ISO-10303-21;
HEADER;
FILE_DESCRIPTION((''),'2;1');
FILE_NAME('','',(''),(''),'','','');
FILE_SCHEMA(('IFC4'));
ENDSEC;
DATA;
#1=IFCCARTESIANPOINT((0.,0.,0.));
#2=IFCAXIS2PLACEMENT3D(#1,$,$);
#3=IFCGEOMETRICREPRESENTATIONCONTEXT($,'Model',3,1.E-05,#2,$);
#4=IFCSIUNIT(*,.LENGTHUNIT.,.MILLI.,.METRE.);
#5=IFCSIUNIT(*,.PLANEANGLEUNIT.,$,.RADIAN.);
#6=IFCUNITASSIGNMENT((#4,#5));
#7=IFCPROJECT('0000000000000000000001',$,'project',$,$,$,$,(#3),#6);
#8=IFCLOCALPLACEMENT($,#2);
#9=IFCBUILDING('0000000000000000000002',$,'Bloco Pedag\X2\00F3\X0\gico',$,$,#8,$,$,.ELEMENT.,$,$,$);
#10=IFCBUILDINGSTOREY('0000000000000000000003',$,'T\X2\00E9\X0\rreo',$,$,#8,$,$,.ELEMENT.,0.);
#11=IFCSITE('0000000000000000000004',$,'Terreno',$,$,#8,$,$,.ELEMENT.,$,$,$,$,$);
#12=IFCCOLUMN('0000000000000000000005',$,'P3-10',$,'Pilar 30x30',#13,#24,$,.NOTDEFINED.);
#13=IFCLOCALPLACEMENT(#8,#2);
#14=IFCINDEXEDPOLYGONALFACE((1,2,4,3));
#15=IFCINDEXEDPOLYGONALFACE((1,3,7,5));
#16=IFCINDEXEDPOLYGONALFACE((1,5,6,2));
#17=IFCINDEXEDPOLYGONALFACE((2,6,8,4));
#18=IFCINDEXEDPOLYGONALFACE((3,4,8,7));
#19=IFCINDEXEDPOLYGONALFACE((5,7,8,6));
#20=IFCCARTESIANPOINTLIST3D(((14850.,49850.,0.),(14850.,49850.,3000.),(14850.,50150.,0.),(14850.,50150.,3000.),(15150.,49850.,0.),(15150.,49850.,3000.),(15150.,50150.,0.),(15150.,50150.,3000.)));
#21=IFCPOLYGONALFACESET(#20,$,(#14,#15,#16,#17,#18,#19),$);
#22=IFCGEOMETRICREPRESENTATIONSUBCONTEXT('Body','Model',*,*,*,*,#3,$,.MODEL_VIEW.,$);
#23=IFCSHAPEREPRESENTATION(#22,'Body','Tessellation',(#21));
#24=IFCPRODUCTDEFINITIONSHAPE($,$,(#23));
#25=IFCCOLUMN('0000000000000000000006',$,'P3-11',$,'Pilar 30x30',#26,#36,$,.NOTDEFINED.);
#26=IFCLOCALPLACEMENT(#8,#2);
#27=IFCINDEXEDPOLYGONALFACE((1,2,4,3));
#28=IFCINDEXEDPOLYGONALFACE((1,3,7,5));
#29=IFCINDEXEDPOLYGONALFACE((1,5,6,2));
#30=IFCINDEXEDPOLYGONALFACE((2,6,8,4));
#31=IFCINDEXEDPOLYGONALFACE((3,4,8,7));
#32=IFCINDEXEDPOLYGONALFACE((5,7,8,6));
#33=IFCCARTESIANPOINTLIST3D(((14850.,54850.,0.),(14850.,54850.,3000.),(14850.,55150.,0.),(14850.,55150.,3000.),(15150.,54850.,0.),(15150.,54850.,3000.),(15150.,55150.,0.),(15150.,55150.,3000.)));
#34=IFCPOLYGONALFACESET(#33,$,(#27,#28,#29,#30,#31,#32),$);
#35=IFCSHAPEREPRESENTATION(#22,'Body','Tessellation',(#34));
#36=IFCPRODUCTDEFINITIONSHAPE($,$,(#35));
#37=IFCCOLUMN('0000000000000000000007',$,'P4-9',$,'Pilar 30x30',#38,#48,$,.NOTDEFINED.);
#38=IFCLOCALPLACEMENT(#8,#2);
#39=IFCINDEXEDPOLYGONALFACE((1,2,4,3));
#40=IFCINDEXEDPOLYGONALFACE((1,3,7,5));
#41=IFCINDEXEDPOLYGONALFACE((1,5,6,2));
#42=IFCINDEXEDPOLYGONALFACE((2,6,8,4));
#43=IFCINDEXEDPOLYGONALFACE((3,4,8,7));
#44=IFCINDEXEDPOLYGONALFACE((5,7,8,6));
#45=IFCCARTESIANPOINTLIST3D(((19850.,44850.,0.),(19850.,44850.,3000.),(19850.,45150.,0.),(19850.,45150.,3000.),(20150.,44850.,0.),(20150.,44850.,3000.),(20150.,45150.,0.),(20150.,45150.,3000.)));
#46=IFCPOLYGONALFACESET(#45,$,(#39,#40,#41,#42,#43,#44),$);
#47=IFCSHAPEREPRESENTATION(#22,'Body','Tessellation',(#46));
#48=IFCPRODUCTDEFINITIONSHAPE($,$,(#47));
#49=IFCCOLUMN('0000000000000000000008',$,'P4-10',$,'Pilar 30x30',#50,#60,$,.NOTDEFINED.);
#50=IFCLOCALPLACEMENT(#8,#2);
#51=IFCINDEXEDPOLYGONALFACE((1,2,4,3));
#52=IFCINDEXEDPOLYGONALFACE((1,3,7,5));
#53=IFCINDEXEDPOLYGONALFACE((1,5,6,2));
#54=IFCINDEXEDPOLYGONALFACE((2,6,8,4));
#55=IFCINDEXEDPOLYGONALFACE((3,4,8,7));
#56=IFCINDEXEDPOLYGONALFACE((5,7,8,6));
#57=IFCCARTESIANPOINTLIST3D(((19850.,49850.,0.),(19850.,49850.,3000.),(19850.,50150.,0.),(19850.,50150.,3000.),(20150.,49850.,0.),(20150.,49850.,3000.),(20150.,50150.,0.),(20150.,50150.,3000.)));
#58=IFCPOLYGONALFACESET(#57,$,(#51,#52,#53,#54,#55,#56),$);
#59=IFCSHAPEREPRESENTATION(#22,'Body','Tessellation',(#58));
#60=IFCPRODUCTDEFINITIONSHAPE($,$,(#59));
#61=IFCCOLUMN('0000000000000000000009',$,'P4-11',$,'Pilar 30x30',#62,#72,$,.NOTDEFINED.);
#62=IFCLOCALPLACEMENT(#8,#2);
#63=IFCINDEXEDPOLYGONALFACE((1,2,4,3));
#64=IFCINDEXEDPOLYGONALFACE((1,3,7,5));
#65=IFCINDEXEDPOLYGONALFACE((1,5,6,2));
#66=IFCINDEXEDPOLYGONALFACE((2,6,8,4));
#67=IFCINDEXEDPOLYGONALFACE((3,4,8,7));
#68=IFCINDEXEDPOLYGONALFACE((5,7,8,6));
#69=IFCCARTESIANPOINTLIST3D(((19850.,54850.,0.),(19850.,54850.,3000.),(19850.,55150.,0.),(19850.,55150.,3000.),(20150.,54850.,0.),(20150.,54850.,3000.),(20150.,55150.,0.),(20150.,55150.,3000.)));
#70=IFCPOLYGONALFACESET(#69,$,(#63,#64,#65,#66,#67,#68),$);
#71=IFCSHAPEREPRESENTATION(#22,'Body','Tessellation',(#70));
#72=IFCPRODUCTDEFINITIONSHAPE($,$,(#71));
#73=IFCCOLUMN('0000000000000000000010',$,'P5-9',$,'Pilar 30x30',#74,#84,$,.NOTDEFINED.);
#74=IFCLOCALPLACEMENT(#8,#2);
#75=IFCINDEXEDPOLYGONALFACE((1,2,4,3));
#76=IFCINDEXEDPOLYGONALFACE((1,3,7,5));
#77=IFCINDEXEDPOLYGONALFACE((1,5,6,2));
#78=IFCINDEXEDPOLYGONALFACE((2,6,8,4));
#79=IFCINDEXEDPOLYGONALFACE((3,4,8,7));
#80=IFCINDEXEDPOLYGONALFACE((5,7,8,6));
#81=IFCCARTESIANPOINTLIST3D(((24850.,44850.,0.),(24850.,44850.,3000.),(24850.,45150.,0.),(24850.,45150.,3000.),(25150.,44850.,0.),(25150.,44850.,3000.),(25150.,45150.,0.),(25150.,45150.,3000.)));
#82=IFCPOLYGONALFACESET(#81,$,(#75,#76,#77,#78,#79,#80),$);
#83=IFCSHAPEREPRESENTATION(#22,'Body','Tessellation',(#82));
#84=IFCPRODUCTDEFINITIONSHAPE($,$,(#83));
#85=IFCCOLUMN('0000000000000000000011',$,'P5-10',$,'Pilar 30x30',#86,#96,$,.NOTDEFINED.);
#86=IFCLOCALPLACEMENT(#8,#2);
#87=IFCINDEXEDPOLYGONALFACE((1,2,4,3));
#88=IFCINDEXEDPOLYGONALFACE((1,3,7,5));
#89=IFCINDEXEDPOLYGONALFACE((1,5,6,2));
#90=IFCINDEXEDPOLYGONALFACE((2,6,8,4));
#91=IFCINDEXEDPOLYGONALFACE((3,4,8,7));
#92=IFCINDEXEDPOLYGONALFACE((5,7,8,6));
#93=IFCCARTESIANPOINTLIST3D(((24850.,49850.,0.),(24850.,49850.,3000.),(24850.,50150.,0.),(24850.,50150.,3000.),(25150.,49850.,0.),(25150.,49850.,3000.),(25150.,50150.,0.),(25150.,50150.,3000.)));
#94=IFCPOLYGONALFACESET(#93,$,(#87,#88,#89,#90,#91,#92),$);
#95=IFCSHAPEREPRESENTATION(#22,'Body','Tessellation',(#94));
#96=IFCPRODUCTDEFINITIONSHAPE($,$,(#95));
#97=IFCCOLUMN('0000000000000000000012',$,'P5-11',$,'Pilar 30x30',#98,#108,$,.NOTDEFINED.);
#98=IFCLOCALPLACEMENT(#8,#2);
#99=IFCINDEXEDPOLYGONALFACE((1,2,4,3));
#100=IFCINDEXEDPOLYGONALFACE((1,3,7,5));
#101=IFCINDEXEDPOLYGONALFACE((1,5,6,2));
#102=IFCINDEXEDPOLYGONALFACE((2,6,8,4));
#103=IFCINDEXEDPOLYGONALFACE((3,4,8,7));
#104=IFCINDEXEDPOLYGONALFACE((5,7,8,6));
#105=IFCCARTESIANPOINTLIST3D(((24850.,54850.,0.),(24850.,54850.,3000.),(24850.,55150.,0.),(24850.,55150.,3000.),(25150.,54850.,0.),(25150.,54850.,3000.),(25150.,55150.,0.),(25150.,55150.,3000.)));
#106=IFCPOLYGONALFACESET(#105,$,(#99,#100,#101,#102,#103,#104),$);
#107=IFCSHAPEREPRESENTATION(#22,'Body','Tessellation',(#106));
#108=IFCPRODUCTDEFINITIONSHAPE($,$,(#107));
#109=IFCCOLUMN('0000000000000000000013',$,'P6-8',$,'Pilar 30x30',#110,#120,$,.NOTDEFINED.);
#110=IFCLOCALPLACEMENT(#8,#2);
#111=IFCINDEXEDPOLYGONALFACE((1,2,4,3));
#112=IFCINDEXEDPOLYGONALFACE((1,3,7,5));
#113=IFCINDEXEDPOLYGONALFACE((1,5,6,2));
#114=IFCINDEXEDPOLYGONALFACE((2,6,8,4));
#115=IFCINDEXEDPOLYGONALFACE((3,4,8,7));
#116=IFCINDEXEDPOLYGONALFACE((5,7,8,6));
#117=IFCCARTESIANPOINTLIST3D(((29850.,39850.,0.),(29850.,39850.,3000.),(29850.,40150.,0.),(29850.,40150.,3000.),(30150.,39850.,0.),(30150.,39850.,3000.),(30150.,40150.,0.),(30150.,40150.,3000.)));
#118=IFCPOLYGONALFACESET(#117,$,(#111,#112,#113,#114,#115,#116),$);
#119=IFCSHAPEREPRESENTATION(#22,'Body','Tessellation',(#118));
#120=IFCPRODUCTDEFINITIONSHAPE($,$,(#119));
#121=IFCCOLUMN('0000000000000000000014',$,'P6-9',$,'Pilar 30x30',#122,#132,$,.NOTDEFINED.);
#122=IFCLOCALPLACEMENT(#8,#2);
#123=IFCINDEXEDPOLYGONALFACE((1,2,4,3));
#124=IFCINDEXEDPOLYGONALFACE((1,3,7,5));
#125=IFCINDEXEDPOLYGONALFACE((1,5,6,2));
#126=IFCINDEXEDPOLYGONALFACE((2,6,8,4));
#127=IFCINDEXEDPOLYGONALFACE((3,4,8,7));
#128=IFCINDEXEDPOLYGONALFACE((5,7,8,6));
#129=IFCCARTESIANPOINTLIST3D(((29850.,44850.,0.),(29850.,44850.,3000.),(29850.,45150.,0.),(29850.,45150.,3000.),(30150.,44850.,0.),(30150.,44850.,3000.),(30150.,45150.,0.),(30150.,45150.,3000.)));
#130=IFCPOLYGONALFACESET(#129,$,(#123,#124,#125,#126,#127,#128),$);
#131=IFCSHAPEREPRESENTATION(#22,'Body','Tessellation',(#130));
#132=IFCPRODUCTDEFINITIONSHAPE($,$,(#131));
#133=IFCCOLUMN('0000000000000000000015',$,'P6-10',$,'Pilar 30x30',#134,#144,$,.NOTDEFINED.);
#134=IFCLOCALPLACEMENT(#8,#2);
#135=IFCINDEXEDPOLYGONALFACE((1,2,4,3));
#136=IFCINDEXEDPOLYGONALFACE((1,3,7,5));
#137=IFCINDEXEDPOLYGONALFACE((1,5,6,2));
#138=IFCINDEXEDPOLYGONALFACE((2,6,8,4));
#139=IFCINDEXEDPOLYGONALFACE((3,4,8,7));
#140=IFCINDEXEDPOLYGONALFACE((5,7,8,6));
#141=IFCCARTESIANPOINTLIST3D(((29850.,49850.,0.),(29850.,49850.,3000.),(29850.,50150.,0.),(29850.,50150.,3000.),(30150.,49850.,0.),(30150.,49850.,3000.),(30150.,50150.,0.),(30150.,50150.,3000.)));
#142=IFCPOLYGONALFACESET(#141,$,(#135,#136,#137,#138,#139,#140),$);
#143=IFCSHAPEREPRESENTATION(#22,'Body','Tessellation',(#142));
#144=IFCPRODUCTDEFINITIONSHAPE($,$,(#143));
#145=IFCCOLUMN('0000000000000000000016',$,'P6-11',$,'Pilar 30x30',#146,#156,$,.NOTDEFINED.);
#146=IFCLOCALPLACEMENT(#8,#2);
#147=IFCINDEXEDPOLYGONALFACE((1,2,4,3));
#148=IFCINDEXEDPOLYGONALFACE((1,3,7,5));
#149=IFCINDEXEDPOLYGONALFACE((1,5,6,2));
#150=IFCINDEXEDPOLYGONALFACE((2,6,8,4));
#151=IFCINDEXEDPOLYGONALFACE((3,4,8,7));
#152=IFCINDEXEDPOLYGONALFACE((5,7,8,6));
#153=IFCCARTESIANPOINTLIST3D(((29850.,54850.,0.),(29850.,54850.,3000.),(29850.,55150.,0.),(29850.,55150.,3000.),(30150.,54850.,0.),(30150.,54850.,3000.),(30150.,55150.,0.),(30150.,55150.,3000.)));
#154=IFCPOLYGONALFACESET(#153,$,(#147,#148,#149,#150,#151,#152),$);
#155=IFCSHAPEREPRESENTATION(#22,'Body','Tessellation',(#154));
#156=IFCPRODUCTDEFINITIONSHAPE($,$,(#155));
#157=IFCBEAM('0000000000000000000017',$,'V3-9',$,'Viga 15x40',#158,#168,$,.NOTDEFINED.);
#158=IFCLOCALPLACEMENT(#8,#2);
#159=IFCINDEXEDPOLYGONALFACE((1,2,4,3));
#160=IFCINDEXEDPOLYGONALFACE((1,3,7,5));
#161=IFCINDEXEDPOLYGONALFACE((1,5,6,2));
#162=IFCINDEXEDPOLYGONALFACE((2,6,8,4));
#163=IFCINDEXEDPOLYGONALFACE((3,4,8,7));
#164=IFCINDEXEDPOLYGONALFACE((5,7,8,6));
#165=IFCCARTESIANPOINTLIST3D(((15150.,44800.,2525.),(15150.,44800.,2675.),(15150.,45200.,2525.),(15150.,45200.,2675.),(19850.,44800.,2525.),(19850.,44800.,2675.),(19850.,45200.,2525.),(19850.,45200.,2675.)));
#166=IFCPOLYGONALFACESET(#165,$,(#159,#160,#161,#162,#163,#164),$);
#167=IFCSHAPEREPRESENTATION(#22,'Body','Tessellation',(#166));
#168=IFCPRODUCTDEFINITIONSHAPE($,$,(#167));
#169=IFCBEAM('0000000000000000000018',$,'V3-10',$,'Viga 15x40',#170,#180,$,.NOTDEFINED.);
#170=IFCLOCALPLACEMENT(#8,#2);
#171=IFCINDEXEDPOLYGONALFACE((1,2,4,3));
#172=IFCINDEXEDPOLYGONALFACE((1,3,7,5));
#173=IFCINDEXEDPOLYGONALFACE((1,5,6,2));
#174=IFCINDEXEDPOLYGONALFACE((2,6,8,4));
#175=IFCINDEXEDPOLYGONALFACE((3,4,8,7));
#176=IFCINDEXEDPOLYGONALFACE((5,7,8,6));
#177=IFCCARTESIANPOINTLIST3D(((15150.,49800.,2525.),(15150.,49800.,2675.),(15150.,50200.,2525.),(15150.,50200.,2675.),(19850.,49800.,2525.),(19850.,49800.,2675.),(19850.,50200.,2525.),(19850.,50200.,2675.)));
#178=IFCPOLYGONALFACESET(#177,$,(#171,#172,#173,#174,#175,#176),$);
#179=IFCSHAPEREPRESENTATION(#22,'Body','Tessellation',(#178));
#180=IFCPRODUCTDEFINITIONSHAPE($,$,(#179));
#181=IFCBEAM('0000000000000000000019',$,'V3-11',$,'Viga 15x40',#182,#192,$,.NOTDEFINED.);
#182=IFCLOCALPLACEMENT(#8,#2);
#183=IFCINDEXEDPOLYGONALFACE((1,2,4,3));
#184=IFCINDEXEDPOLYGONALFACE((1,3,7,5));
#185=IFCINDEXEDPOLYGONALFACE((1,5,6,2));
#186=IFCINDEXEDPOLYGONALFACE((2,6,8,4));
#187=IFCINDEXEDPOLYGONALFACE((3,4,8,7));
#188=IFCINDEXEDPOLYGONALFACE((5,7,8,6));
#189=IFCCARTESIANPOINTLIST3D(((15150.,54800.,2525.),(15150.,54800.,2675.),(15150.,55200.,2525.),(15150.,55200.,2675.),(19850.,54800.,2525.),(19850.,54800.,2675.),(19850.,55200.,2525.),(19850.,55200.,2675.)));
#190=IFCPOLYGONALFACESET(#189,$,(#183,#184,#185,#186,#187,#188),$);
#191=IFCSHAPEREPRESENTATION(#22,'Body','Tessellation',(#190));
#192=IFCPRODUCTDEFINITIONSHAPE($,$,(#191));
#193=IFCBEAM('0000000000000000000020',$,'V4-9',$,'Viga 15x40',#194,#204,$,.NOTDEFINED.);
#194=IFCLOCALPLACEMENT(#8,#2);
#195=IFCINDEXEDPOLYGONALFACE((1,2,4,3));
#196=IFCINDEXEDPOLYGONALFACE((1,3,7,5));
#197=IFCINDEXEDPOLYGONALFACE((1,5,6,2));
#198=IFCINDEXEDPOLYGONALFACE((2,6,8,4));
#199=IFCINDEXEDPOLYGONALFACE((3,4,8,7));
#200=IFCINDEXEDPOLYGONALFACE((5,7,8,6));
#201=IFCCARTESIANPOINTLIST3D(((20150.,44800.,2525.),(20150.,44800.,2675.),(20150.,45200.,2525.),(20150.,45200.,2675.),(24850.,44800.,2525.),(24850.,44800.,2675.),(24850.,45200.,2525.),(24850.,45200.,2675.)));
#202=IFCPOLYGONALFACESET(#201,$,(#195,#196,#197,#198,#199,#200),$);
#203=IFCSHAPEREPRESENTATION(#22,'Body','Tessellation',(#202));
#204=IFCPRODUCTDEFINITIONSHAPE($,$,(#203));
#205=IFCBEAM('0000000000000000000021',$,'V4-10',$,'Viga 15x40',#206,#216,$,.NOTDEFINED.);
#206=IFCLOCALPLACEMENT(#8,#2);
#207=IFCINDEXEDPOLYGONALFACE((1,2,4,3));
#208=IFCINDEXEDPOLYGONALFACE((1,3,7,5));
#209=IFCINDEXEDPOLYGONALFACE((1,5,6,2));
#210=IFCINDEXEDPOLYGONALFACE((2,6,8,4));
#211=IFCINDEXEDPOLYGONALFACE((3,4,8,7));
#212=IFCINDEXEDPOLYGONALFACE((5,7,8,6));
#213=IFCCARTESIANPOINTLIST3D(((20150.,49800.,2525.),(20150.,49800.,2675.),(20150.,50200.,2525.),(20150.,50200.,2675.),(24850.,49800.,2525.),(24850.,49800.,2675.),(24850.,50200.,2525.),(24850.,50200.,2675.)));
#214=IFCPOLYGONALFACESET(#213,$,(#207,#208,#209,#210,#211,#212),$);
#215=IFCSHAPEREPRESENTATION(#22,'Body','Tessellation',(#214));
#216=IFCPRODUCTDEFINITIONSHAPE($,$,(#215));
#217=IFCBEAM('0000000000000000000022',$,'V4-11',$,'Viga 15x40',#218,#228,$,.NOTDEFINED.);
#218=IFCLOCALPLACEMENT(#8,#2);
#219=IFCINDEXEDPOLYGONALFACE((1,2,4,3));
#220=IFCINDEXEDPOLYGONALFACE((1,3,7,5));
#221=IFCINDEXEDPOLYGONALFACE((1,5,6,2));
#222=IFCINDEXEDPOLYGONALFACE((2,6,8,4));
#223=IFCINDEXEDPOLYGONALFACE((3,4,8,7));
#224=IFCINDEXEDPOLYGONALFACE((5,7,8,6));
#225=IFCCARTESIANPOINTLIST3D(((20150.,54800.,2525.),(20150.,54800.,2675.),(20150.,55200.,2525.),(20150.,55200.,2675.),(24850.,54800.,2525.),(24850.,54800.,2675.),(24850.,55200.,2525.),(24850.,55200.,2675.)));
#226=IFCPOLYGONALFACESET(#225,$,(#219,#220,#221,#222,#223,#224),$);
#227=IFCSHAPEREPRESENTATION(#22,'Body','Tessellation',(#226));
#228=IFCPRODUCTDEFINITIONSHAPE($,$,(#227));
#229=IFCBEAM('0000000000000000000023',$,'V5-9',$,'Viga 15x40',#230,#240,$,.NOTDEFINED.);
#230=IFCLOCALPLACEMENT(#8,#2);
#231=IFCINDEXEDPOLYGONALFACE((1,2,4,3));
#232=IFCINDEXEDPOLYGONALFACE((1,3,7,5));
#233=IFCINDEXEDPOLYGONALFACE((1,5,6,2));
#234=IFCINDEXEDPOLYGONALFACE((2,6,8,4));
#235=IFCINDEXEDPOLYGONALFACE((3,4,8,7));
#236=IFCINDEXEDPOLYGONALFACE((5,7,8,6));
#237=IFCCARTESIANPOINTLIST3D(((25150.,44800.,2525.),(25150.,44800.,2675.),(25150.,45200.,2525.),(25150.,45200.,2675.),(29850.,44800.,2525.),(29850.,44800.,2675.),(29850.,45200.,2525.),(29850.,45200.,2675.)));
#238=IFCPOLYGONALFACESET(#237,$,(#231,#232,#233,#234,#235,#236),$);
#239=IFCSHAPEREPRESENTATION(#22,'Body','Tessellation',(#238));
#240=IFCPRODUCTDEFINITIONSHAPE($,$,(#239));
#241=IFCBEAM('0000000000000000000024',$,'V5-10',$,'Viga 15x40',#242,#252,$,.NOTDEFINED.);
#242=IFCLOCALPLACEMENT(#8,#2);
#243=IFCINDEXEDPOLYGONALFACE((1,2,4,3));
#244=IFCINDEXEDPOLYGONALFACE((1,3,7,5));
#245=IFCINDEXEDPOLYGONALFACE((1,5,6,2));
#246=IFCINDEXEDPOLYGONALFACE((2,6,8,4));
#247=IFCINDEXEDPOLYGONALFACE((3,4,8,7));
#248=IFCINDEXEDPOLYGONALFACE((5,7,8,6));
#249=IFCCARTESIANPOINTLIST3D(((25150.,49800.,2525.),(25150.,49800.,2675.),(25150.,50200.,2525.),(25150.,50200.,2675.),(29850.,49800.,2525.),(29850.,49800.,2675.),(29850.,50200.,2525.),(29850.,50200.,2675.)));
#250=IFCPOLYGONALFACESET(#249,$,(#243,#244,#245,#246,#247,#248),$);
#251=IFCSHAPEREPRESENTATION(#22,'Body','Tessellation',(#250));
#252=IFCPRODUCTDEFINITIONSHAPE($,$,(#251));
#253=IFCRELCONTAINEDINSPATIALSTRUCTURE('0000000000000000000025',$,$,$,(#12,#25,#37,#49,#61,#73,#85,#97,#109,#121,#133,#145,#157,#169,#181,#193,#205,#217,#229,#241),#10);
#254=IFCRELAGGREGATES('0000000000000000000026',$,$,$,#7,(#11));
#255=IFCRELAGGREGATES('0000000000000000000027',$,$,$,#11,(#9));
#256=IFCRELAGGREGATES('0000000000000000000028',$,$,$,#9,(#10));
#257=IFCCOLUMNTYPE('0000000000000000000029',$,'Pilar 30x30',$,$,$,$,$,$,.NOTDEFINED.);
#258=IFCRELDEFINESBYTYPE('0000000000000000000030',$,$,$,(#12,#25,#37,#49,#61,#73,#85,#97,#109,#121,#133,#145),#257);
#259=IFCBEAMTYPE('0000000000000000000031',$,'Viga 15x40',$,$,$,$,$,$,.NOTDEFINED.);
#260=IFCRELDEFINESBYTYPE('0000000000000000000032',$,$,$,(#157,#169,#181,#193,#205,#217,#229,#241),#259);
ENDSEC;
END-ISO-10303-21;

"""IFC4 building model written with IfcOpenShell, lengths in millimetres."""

from ifc_helpers import new_model, si_unit, frame, origin, origin_2d, place, context, subcontext, project, spatial, rectangle, extrude, type_object, element, save


model = new_model("IFC4")

# Units and contexts
model_context = context("Model", 3, precision=1e-05, world=origin())
body_context = subcontext(model_context, "Body", "Model", "MODEL_VIEW")
ifc_project = project(units=[si_unit("LENGTHUNIT", "METRE", prefix="MILLI"), si_unit("PLANEANGLEUNIT", "RADIAN")], contexts=[model_context])

# Site, building, storey
placement = place(None, origin())
site = spatial("IfcSite", under=ifc_project, at=placement, Name="Terreno", CompositionType="ELEMENT")
building = spatial("IfcBuilding", under=site, at=placement, Name="Bloco Pedagógico", CompositionType="ELEMENT")
storey = spatial("IfcBuildingStorey", under=building, at=placement, Name="Térreo", CompositionType="ELEMENT", Elevation=0.0)

# Columns
column_type = type_object("IfcColumnType", Name="Pilar 30x30", PredefinedType="NOTDEFINED")
for number, where, z_axis, x_axis, name in (
    (1, (15000.0, 50000.0, 0.0), (0.0, 0.0, 1.0), (1.0, 0.0, 0.0), "P3-10"),
    (2, (15000.0, 55000.0, 0.0), (0.0, 0.0, 1.0), (1.0, 0.0, 0.0), "P3-11"),
    (3, (20000.0, 45000.0, 0.0), (0.0, 0.0, 1.0), (1.0, 0.0, 0.0), "P4-9"),
    (4, (20000.0, 50000.0, 0.0), (0.0, 0.0, 1.0), (1.0, 0.0, 0.0), "P4-10"),
    (5, (20000.0, 55000.0, 0.0), (0.0, 0.0, 1.0), (1.0, 0.0, 0.0), "P4-11"),
    (6, (25000.0, 45000.0, 0.0), (0.0, 0.0, 1.0), (1.0, 0.0, 0.0), "P5-9"),
    (7, (25000.0, 50000.0, 0.0), (0.0, 0.0, 1.0), (1.0, 0.0, 0.0), "P5-10"),
    (8, (25000.0, 55000.0, 0.0), (0.0, 0.0, 1.0), (1.0, 0.0, 0.0), "P5-11"),
    (9, (30000.0, 40000.0, 0.0), (0.0, 0.0, 1.0), (1.0, 0.0, 0.0), "P6-8"),
    (10, (30000.0, 45000.0, 0.0), (0.0, 0.0, 1.0), (1.0, 0.0, 0.0), "P6-9"),
    (11, (30000.0, 50000.0, 0.0), (0.0, 0.0, 1.0), (1.0, 0.0, 0.0), "P6-10"),
    (12, (30000.0, 55000.0, 0.0), (0.0, 0.0, 1.0), (1.0, 0.0, 0.0), "P6-11"),
):
    element("IfcColumn", number, at=place(None, frame(where, z_axis=z_axis, x_axis=x_axis)), inside=storey, type_object=column_type, Name=name, ObjectType="Pilar 30x30", PredefinedType="NOTDEFINED", context=body_context, shape_type="SweptSolid", body=[
        extrude(rectangle(XDim=300.0, YDim=300.0, at=origin_2d()), None, (0.0, 0.0, 1.0), 3000.0),
    ])

# Beams
beam_type = type_object("IfcBeamType", Name="Viga 15x40", PredefinedType="NOTDEFINED")
for number, where, z_axis, x_axis, name in (
    (13, (15150.0, 45000.0, 2600.0), (1.0, 0.0, 0.0), (0.0, 1.0, 0.0), "V3-9"),
    (14, (15150.0, 50000.0, 2600.0), (1.0, 0.0, 0.0), (0.0, 1.0, 0.0), "V3-10"),
    (15, (15150.0, 55000.0, 2600.0), (1.0, 0.0, 0.0), (0.0, 1.0, 0.0), "V3-11"),
    (16, (20150.0, 45000.0, 2600.0), (1.0, 0.0, 0.0), (0.0, 1.0, 0.0), "V4-9"),
    (17, (20150.0, 50000.0, 2600.0), (1.0, 0.0, 0.0), (0.0, 1.0, 0.0), "V4-10"),
    (18, (20150.0, 55000.0, 2600.0), (1.0, 0.0, 0.0), (0.0, 1.0, 0.0), "V4-11"),
    (19, (25150.0, 45000.0, 2600.0), (1.0, 0.0, 0.0), (0.0, 1.0, 0.0), "V5-9"),
    (20, (25150.0, 50000.0, 2600.0), (1.0, 0.0, 0.0), (0.0, 1.0, 0.0), "V5-10"),
):
    element("IfcBeam", number, at=place(None, frame(where, z_axis=z_axis, x_axis=x_axis)), inside=storey, type_object=beam_type, Name=name, ObjectType="Viga 15x40", PredefinedType="NOTDEFINED", context=body_context, shape_type="SweptSolid", body=[
        extrude(rectangle(XDim=400.0, YDim=150.0, at=origin_2d()), None, (0.0, 0.0, 1.0), 4700.0),
    ])

save(model, "model.ifc")
